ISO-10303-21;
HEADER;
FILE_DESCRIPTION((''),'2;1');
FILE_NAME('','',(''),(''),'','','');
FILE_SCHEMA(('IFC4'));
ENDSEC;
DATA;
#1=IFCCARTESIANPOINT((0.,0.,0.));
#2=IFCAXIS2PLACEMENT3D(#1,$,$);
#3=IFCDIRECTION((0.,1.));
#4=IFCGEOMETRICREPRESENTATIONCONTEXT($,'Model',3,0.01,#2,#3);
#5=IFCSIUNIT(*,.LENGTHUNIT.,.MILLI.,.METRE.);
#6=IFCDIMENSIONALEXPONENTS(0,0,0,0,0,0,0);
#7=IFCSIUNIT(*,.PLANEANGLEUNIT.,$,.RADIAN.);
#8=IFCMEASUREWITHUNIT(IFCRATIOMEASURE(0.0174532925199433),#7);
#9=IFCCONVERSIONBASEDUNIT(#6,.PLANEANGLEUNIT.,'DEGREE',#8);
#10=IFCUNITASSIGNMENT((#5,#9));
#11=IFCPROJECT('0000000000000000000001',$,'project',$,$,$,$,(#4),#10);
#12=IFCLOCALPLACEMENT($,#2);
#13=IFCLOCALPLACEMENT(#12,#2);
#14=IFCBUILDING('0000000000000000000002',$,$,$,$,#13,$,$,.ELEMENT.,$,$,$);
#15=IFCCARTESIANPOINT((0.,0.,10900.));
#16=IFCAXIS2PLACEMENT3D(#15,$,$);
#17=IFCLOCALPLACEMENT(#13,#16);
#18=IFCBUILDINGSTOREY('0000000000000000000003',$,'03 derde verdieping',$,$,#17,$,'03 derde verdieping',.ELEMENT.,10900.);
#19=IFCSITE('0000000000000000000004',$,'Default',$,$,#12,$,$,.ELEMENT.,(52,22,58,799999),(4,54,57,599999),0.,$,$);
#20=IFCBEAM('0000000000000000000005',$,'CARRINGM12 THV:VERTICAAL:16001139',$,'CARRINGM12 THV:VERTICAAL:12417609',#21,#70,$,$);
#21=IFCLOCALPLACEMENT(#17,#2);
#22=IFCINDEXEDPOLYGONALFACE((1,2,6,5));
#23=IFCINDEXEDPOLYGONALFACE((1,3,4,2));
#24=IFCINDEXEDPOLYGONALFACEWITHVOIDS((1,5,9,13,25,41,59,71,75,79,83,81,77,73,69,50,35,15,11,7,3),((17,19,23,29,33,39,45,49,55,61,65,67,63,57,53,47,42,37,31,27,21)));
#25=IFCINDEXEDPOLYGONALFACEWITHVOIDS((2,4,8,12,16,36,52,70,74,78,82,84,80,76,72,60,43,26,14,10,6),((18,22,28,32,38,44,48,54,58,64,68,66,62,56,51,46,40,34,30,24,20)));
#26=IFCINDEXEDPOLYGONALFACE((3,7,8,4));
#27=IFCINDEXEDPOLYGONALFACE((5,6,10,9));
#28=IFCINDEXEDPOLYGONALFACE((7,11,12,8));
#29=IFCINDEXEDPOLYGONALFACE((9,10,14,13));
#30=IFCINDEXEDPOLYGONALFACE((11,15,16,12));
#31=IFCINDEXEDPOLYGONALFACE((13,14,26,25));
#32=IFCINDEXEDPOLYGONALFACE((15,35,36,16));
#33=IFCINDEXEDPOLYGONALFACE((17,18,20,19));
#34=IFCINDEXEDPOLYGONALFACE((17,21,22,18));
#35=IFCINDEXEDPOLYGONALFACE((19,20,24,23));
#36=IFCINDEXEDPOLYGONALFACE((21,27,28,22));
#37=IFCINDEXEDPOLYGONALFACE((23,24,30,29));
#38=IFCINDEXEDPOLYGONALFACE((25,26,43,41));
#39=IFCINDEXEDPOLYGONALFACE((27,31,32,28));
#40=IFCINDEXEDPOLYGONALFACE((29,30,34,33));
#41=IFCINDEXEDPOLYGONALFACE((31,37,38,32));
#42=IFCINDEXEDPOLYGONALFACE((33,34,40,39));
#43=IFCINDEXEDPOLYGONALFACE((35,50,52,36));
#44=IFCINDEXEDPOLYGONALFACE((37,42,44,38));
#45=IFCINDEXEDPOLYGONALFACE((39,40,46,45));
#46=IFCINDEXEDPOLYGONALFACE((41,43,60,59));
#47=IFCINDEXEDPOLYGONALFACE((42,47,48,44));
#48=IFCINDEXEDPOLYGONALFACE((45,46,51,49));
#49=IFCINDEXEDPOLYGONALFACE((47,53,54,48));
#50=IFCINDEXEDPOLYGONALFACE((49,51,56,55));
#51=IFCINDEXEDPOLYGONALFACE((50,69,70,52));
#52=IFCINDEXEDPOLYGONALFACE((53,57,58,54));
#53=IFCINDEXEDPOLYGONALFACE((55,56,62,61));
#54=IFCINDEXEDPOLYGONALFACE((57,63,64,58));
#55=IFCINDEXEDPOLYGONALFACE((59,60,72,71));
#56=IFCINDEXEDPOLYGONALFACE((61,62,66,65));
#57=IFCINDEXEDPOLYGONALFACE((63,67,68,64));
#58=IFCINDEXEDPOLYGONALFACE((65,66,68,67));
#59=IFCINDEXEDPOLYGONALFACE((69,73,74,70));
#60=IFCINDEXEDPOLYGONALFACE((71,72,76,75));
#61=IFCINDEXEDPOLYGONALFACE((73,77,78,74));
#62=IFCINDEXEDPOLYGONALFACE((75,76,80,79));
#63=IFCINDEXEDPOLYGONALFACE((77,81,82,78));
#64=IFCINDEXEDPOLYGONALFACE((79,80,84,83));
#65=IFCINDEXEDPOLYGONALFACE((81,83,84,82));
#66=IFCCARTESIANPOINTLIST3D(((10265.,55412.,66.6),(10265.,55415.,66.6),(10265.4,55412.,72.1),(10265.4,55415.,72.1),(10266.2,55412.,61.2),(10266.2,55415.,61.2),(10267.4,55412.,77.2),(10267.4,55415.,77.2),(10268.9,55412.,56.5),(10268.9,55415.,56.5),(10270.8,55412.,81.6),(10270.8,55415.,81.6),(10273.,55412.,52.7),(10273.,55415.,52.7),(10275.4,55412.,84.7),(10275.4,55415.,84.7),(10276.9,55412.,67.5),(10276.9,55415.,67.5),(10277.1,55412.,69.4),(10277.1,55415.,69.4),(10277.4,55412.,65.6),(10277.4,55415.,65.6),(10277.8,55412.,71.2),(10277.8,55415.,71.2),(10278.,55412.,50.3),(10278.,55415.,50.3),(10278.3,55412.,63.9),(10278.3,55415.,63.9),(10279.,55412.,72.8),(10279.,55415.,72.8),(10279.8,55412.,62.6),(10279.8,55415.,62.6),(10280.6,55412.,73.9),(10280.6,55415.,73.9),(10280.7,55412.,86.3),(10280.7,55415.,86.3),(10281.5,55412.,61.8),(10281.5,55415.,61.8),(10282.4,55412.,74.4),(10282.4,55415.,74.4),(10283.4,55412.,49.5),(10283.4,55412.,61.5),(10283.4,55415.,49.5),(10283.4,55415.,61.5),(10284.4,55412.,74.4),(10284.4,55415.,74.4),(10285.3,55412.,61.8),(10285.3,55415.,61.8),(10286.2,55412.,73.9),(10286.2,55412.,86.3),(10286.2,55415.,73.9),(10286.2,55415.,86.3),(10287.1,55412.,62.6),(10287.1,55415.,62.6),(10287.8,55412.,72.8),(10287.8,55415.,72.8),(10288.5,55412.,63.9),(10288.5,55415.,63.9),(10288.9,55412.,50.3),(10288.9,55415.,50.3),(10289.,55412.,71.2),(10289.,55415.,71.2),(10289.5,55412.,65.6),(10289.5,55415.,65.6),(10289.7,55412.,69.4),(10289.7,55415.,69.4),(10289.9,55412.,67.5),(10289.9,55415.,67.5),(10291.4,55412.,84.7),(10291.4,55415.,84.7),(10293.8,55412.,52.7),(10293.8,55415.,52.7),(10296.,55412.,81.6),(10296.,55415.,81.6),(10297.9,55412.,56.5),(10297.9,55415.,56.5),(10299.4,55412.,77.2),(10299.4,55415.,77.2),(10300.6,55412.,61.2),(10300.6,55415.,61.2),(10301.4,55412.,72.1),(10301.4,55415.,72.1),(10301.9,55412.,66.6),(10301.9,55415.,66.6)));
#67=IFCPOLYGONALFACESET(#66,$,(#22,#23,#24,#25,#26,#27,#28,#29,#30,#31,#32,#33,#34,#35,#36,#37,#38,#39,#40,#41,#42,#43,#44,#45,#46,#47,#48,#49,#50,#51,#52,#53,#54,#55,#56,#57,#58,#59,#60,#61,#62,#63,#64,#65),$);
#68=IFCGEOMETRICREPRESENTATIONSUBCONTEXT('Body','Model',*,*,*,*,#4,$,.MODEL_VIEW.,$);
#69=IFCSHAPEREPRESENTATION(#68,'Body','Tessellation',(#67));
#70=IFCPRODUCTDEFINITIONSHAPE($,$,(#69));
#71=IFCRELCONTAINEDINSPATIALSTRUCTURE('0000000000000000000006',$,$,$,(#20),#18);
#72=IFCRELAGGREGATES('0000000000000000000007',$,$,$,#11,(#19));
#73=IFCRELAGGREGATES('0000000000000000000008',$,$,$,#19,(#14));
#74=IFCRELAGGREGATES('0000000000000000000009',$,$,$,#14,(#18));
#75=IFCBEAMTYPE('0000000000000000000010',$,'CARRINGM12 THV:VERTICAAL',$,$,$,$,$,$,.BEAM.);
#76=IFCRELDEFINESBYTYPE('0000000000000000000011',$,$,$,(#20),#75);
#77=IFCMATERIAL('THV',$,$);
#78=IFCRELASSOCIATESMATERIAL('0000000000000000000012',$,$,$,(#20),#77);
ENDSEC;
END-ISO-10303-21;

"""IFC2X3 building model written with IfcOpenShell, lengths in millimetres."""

from ifc_helpers import new_model, entity, si_unit, converted_unit, direction, frame, origin, origin_2d_with_axis, place, context, subcontext, project, spatial, hollow_circle, extrude, material, type_object, element, save


model = new_model("IFC2X3")

# Units and contexts
model_context = context("Model", 3, precision=0.01, world=origin(), true_north=direction((0.0, 1.0)))
body_context = subcontext(model_context, "Body", "Model", "MODEL_VIEW")
ifc_project = project(units=[si_unit("LENGTHUNIT", "METRE", prefix="MILLI"), converted_unit("PLANEANGLEUNIT", "DEGREE", entity("IfcRatioMeasure", 0.0174532925199433), si_unit("PLANEANGLEUNIT", "RADIAN"), dimensions=[0, 0, 0, 0, 0, 0, 0])], contexts=[model_context])

# Site, building, storey
site_placement = place(None, origin())
site = spatial("IfcSite", under=ifc_project, at=site_placement, Name="Default", CompositionType="ELEMENT", RefLatitude=(52, 22, 58, 799999), RefLongitude=(4, 54, 57, 599999), RefElevation=0.0)
building_placement = place(site_placement, origin())
building = spatial("IfcBuilding", under=site, at=building_placement, CompositionType="ELEMENT")
storey_placement = place(building_placement, frame((0.0, 0.0, 10900.0)))
storey = spatial("IfcBuildingStorey", under=building, at=storey_placement, Name="03 derde verdieping", LongName="03 derde verdieping", CompositionType="ELEMENT", Elevation=10900.0)

# Beam
ifc_material_1 = material(Name="THV")
beam_type_1 = type_object("IfcBeamType", Name="CARRINGM12 THV:VERTICAAL", PredefinedType="BEAM")
beam_1_placement = place(storey_placement, origin())
element("IfcBeam", 1, at=beam_1_placement, inside=storey, type_object=beam_type_1, material=ifc_material_1, Name="CARRINGM12 THV:VERTICAAL:16001139", ObjectType="CARRINGM12 THV:VERTICAAL:12417609", context=body_context, shape_type="SweptSolid", body=[
    extrude(hollow_circle(Radius=18.5, WallThickness=12.0, at=origin_2d_with_axis()), frame((10283.4, 55412.0, 68.0), z_axis=(0.0, 1.0, 0.0), x_axis=(0.0, 0.0, -1.0)), (0.0, 0.0, 1.0), 3.0),
])

save(model, "model.ifc")
